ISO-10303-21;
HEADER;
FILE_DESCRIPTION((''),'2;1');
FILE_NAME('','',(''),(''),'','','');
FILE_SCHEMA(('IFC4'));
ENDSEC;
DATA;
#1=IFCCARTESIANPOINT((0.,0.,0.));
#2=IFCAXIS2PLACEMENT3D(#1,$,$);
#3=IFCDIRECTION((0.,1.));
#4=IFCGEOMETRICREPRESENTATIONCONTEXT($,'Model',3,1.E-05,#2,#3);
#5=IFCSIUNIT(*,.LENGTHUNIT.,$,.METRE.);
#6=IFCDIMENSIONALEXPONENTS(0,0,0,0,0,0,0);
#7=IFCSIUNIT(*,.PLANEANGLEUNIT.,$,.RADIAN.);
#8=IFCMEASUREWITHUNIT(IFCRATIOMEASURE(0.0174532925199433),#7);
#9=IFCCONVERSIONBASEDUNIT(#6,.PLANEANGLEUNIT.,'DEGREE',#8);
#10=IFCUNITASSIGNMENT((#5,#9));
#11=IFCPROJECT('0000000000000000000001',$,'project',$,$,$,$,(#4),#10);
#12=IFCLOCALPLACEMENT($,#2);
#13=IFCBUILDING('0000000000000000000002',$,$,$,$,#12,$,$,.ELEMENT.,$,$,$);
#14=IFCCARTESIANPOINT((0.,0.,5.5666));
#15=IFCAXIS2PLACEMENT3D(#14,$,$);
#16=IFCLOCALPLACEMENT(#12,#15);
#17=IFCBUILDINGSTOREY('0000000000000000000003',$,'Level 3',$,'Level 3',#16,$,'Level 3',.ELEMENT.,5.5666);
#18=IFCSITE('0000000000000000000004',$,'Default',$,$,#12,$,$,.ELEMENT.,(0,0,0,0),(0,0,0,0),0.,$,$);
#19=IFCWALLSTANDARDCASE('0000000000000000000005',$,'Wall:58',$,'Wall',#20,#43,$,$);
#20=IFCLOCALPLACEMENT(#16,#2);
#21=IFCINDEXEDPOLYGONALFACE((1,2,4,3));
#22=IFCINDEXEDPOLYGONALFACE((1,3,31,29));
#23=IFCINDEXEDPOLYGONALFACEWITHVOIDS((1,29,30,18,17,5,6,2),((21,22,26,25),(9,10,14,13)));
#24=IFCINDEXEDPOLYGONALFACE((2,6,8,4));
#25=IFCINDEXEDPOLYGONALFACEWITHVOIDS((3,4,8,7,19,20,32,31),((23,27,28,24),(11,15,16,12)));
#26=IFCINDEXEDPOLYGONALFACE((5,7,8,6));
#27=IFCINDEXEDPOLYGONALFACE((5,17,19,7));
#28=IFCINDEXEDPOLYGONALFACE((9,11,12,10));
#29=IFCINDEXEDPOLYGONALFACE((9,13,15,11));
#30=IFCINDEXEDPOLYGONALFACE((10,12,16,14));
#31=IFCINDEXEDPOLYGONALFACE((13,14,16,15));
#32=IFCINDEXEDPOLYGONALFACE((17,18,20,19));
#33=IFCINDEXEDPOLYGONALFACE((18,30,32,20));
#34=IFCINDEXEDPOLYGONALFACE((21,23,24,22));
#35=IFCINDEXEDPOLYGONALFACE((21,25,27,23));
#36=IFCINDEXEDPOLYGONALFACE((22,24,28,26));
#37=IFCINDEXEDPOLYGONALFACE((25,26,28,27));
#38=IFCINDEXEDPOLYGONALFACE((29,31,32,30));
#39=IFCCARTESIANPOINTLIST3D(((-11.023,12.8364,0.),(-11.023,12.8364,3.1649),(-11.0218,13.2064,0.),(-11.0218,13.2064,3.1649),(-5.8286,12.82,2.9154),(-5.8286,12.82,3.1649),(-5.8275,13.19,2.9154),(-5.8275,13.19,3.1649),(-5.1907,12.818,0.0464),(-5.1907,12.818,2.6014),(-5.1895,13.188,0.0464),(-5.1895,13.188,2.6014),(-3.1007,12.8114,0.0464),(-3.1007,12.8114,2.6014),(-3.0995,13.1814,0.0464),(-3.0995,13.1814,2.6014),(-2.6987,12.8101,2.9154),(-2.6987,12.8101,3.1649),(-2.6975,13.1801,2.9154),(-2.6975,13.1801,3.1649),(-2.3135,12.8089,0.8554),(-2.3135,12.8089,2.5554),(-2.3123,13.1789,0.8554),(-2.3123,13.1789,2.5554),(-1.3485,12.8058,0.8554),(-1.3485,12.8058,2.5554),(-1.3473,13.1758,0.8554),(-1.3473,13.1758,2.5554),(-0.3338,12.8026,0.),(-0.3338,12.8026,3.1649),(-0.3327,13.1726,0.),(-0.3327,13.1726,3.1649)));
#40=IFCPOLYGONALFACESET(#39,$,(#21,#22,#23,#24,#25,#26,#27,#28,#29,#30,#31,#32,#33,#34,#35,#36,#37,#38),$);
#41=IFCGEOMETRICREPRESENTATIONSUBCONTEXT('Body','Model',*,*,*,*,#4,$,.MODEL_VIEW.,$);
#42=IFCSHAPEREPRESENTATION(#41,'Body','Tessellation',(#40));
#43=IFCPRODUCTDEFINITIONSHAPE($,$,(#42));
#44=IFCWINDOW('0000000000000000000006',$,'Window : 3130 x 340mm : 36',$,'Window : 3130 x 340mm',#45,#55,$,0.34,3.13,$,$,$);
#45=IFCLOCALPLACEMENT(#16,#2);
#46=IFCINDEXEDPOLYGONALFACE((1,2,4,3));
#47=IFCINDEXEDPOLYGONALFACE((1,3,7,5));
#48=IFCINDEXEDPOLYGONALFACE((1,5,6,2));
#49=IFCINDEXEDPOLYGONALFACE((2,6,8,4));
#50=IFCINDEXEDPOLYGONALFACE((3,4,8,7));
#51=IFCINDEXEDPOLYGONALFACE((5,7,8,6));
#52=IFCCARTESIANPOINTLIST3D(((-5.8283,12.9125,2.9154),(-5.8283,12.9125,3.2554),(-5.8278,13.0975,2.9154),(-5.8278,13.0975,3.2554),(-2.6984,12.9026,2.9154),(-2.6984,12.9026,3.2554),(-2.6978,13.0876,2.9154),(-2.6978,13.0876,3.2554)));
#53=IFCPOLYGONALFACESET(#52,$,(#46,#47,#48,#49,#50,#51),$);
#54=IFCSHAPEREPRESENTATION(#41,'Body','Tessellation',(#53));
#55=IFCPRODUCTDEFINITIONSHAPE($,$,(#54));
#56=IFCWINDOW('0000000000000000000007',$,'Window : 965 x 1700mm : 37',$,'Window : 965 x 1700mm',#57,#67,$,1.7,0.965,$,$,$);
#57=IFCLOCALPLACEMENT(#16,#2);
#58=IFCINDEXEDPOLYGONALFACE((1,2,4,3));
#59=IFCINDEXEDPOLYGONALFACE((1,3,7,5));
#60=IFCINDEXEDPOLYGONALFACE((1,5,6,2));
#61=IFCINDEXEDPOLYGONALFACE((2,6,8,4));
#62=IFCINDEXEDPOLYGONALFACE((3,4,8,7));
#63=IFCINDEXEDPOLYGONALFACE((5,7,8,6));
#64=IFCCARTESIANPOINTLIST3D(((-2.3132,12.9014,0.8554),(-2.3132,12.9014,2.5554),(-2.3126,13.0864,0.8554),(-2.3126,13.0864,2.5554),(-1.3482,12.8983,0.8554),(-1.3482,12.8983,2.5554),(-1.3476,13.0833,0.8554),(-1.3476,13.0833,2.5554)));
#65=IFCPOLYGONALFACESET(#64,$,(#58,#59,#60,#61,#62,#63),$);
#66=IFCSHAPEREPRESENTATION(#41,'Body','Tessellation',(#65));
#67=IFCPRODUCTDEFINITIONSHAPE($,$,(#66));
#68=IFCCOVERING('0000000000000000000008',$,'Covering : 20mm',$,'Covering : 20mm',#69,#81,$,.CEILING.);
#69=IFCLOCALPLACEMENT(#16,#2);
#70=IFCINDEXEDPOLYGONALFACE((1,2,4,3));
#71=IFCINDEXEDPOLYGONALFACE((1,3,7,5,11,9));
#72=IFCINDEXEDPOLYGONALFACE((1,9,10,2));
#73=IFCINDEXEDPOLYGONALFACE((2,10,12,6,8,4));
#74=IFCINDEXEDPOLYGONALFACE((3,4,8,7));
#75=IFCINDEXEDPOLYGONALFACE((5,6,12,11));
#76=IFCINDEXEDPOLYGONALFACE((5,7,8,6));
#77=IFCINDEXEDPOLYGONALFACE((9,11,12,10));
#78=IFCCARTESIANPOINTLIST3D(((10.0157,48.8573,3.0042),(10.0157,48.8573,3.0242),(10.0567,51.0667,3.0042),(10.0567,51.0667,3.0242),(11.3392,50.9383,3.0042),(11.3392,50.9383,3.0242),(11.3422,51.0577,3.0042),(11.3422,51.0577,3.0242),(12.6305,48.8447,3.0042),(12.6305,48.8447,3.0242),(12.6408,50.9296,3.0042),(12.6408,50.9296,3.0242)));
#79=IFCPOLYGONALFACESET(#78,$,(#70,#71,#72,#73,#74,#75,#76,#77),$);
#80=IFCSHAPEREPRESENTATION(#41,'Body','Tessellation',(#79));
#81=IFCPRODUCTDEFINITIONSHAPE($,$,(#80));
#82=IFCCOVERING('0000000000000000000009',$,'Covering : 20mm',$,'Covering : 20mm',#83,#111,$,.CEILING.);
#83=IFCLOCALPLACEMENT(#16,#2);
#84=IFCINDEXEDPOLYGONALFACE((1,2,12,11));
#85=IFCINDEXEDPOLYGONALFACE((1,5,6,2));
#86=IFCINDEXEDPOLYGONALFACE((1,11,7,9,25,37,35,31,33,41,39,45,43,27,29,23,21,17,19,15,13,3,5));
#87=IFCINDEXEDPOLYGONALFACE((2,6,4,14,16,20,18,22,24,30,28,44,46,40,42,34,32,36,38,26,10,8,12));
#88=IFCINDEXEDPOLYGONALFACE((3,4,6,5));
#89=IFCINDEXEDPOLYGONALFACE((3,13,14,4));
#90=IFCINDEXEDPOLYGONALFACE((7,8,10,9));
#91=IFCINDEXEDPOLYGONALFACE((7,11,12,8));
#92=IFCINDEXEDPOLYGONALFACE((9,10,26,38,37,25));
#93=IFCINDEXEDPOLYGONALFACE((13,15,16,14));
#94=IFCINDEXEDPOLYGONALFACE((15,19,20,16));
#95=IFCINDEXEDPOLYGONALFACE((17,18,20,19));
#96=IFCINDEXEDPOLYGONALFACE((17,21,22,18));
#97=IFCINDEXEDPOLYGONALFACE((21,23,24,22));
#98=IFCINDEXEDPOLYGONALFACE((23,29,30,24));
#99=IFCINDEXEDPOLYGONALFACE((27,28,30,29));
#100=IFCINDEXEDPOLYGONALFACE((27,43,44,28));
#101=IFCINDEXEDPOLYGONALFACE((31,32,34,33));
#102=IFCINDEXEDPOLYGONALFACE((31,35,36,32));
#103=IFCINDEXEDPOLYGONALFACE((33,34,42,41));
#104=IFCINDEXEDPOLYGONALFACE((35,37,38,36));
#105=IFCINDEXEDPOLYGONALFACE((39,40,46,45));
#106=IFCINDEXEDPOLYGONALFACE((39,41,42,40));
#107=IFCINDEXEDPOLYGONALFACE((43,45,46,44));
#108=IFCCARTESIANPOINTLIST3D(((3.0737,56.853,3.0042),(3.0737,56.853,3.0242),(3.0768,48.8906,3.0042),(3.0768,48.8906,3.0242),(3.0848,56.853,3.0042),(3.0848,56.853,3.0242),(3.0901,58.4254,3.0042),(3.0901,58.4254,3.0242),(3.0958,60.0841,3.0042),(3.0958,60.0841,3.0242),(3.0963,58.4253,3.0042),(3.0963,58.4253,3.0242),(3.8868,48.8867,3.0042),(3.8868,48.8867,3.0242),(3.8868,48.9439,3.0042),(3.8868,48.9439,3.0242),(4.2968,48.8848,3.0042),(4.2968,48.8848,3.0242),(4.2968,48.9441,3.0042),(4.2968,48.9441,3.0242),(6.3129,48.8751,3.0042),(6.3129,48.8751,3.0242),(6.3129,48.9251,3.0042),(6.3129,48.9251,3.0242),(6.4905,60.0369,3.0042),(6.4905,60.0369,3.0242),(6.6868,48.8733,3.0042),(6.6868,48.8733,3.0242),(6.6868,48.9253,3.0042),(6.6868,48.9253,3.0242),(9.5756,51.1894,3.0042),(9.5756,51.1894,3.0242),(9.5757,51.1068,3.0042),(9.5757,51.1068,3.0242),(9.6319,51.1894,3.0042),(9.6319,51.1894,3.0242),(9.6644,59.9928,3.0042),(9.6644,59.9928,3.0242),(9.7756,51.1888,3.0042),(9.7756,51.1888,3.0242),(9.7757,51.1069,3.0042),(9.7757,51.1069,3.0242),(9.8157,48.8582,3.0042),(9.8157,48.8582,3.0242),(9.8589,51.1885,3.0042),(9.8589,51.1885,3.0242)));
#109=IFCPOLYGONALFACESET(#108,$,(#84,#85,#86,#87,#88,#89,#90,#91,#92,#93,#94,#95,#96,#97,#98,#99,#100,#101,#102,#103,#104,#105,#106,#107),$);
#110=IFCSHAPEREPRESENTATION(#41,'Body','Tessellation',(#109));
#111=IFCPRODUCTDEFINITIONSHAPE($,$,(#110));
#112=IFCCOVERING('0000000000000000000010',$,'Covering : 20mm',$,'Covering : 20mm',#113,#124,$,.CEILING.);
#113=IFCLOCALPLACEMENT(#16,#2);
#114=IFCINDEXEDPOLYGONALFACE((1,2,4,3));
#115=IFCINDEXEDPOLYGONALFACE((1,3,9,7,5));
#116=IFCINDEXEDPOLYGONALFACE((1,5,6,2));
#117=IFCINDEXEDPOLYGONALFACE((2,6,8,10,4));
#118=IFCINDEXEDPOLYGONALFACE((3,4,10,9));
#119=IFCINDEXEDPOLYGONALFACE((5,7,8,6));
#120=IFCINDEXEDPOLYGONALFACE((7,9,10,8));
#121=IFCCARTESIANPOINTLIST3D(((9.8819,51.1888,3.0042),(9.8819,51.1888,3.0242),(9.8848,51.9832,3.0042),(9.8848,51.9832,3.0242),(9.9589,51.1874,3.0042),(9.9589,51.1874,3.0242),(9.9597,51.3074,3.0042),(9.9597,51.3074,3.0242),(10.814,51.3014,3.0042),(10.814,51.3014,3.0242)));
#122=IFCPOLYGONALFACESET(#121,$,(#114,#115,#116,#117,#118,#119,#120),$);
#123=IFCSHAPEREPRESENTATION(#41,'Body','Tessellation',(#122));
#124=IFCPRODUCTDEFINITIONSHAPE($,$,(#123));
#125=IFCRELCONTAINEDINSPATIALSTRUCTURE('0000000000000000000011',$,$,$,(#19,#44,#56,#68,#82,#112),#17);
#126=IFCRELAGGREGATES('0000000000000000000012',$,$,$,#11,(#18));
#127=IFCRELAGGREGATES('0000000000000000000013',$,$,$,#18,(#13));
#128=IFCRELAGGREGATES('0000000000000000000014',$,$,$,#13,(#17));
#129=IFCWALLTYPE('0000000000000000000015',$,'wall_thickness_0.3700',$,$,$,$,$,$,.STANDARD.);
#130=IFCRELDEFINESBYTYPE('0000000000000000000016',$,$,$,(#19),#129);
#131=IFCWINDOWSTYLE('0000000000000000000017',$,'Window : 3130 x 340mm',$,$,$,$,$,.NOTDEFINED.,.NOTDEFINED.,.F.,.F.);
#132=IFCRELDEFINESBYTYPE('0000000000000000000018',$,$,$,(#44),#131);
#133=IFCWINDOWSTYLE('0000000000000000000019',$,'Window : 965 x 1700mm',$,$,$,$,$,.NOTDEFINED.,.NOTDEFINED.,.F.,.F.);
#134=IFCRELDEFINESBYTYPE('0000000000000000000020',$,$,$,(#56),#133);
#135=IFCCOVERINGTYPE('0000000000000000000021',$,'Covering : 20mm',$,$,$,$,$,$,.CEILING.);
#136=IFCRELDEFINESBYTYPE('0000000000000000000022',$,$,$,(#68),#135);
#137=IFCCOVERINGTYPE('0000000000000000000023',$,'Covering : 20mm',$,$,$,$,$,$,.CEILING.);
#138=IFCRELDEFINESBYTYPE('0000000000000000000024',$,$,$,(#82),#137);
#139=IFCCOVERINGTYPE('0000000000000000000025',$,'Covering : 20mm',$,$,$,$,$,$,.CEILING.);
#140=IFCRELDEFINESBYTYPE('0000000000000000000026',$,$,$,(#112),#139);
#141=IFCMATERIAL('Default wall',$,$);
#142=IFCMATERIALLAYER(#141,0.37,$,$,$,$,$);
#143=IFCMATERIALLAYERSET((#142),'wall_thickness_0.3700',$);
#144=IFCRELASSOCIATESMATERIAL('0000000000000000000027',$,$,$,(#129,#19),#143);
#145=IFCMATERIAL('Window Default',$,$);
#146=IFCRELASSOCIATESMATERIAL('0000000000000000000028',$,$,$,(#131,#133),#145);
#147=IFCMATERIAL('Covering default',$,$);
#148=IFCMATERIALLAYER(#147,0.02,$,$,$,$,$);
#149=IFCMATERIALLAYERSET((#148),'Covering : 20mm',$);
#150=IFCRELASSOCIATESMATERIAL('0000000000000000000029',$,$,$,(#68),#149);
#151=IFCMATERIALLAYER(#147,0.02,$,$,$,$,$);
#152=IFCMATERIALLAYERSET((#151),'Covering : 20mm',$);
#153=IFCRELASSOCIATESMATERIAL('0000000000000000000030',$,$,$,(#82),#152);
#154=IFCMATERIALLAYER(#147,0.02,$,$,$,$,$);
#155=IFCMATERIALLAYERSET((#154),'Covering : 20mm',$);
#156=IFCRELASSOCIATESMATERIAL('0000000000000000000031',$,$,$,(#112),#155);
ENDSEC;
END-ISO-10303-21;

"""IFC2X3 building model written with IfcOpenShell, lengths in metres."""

from ifc_helpers import new_model, entity, si_unit, converted_unit, direction, frame, frame_2d, origin, origin_with_axes, origin_2d_with_axis, place, context, subcontext, project, spatial, polyline, rectangle, outline, extrude, source, transform, mapped, material, layer, layer_set, layer_usage, type_object, type_shapes, element, fill, save


model = new_model("IFC2X3")

# Units and contexts
model_context = context("Model", 3, precision=1e-05, world=origin(), true_north=direction((0.0, 1.0)))
body_context = subcontext(model_context, "Body", "Model", "MODEL_VIEW")
ifc_project = project(units=[si_unit("LENGTHUNIT", "METRE"), converted_unit("PLANEANGLEUNIT", "DEGREE", entity("IfcRatioMeasure", 0.0174532925199433), si_unit("PLANEANGLEUNIT", "RADIAN"), dimensions=[0, 0, 0, 0, 0, 0, 0])], contexts=[model_context])

# Site, building, storey
placement = place(None, origin())
site = spatial("IfcSite", under=ifc_project, at=placement, Name="Default", CompositionType="ELEMENT", RefLatitude=(0, 0, 0, 0), RefLongitude=(0, 0, 0, 0), RefElevation=0.0)
building = spatial("IfcBuilding", under=site, at=placement, CompositionType="ELEMENT")
storey_placement = place(placement, frame((0.0, 0.0, 5.5666)))
storey = spatial("IfcBuildingStorey", under=building, at=storey_placement, Name="Level 3", ObjectType="Level 3", LongName="Level 3", CompositionType="ELEMENT", Elevation=5.5666)

# Wall, openings, windows
ifc_material_1 = material(Name="Default wall")
ifc_layer_1 = layer(ifc_material_1, 0.37)
ifc_layer_set_1 = layer_set([ifc_layer_1], Name="wall_thickness_0.3700")
ifc_layer_usage_1 = layer_usage(ifc_layer_set_1, "AXIS2", "POSITIVE", -0.185)
wall_type = type_object("IfcWallType", Name="wall_thickness_0.3700", PredefinedType="STANDARD", material=ifc_layer_set_1)
wall_placement = place(storey_placement, frame((-11.0224, 13.0214, 0.0), z_axis=(0.0, 0.0, 1.0), x_axis=(0.999995, -0.003165, 0.0)))
wall = element("IfcWallStandardCase", 1, at=wall_placement, inside=storey, type_object=wall_type, material=ifc_layer_usage_1, Name="Wall:58", ObjectType="Wall", context=body_context, shape_type="SweptSolid", body=[
    extrude(outline(polyline([(10.6892, -0.185), (10.6892, 0.185), (0.0, 0.185), (0.0, -0.185), (10.6892, -0.185)])), origin(), (0.0, 0.0, 1.0), 3.1649),
])
opening_1_placement = place(wall_placement, frame((5.8323, -0.185, 0.0464)))
element("IfcOpeningElement", 2, at=opening_1_placement, cuts=wall, ObjectType="Opening", context=body_context, shape_type="SweptSolid", body=[
    extrude(rectangle(XDim=2.09, YDim=2.555, at=frame_2d((1.2775, 1.045), x_axis=(0.0, 1.0))), frame((0.0, 0.0, 0.0), z_axis=(0.0, 1.0, 0.0), x_axis=(0.0, 0.0, 1.0)), (0.0, 0.0, 1.0), 0.37),
])
opening_2_placement = place(wall_placement, frame((5.1943, -0.185, 2.9154)))
opening_2 = element("IfcOpeningElement", 3, at=opening_2_placement, cuts=wall, ObjectType="Opening", context=body_context, shape_type="SweptSolid", body=[
    extrude(rectangle(XDim=3.13, YDim=0.34, at=frame_2d((0.17, 1.565), x_axis=(0.0, 1.0))), frame((0.0, 0.0, 0.0), z_axis=(0.0, 1.0, 0.0), x_axis=(0.0, 0.0, 1.0)), (0.0, 0.0, 1.0), 0.37),
])
opening_3_placement = place(wall_placement, frame((8.7095, -0.185, 0.8554)))
opening_3 = element("IfcOpeningElement", 4, at=opening_3_placement, cuts=wall, ObjectType="Opening", context=body_context, shape_type="SweptSolid", body=[
    extrude(rectangle(XDim=0.965, YDim=1.7, at=frame_2d((0.85, 0.4825), x_axis=(0.0, 1.0))), frame((0.0, 0.0, 0.0), z_axis=(0.0, 1.0, 0.0), x_axis=(0.0, 0.0, 1.0)), (0.0, 0.0, 1.0), 0.37),
])
ifc_material_2 = material(Name="Window Default")
window_style_1 = type_object("IfcWindowStyle", Name="Window : 3130 x 340mm", ConstructionType="NOTDEFINED", OperationType="NOTDEFINED", ParameterTakesPrecedence=False, Sizeable=False, material=ifc_material_2)
shared_shape_1 = source(origin(), body_context, "Body", "SweptSolid", [
    extrude(rectangle(XDim=0.185, YDim=3.13, at=origin_2d_with_axis()), frame((1.565, 0.185, 0.0), z_axis=(0.0, 0.0, 1.0), x_axis=(0.0, 1.0, 0.0)), (0.0, 0.0, 1.0), 0.34),
])
type_shapes(window_style_1, [shared_shape_1])
window_1_placement = place(opening_2_placement, origin())
window_1 = element("IfcWindow", 5, at=window_1_placement, inside=storey, type_object=window_style_1, Name="Window : 3130 x 340mm : 36", ObjectType="Window : 3130 x 340mm", OverallHeight=0.34, OverallWidth=3.13, context=body_context, shape_type="MappedRepresentation", body=[
    mapped(shared_shape_1, transform((0.0, 0.0, 0.0), scale=1.0)),
])
fill(opening_2, window_1)
window_style_2 = type_object("IfcWindowStyle", Name="Window : 965 x 1700mm", ConstructionType="NOTDEFINED", OperationType="NOTDEFINED", ParameterTakesPrecedence=False, Sizeable=False, material=ifc_material_2)
shared_shape_2 = source(origin(), body_context, "Body", "SweptSolid", [
    extrude(rectangle(XDim=0.185, YDim=0.965, at=origin_2d_with_axis()), frame((0.4825, 0.185, 0.0), z_axis=(0.0, 0.0, 1.0), x_axis=(0.0, 1.0, 0.0)), (0.0, 0.0, 1.0), 1.7),
])
type_shapes(window_style_2, [shared_shape_2])
window_2_placement = place(opening_3_placement, origin())
window_2 = element("IfcWindow", 6, at=window_2_placement, inside=storey, type_object=window_style_2, Name="Window : 965 x 1700mm : 37", ObjectType="Window : 965 x 1700mm", OverallHeight=1.7, OverallWidth=0.965, context=body_context, shape_type="MappedRepresentation", body=[
    mapped(shared_shape_2, transform((0.0, 0.0, 0.0), scale=1.0)),
])
fill(opening_3, window_2)

# Coverings
ifc_material_3 = material(Name="Covering default")
ifc_layer_2 = layer(ifc_material_3, 0.02)
ifc_layer_set_2 = layer_set([ifc_layer_2], Name="Covering : 20mm")
ifc_layer_usage_2 = layer_usage(ifc_layer_set_2, "AXIS3", "POSITIVE", 0.0)
covering_type_1 = type_object("IfcCoveringType", Name="Covering : 20mm", PredefinedType="CEILING")
covering_1_placement = place(placement, frame((0.0, 0.0, 8.5708)))
element("IfcCovering", 7, at=covering_1_placement, inside=storey, type_object=covering_type_1, material=ifc_layer_usage_2, Name="Covering : 20mm", ObjectType="Covering : 20mm", PredefinedType="CEILING", context=body_context, shape_type="SweptSolid", body=[
    extrude(outline(polyline([(10.0567, 51.0667), (11.3422, 51.0577), (11.3392, 50.9383), (12.6408, 50.9296), (12.6305, 48.8447), (10.0157, 48.8573), (10.0567, 51.0667)])), origin_with_axes(), (0.0, 0.0, 1.0), 0.02),
])
ifc_layer_3 = layer(ifc_material_3, 0.02)
ifc_layer_set_3 = layer_set([ifc_layer_3], Name="Covering : 20mm")
ifc_layer_usage_3 = layer_usage(ifc_layer_set_3, "AXIS3", "POSITIVE", 0.0)
covering_type_2 = type_object("IfcCoveringType", Name="Covering : 20mm", PredefinedType="CEILING")
covering_2_placement = place(placement, frame((0.0, 0.0, 8.5708)))
element("IfcCovering", 8, at=covering_2_placement, inside=storey, type_object=covering_type_2, material=ifc_layer_usage_3, Name="Covering : 20mm", ObjectType="Covering : 20mm", PredefinedType="CEILING", context=body_context, shape_type="SweptSolid", body=[
    extrude(outline(polyline([(3.0848, 56.853), (3.0737, 56.853), (3.0963, 58.4253), (3.0901, 58.4254), (3.0958, 60.0841), (6.4905, 60.0369), (9.6644, 59.9928), (9.6319, 51.1894), (9.5756, 51.1894), (9.5757, 51.1068), (9.7757, 51.1069), (9.7756, 51.1888), (9.8589, 51.1885), (9.8157, 48.8582), (6.6868, 48.8733), (6.6868, 48.9253), (6.3129, 48.9251), (6.3129, 48.8751), (4.2968, 48.8848), (4.2968, 48.9441), (3.8868, 48.9439), (3.8868, 48.8867), (3.0768, 48.8906), (3.0848, 56.853)])), origin_with_axes(), (0.0, 0.0, 1.0), 0.02),
])
ifc_layer_4 = layer(ifc_material_3, 0.02)
ifc_layer_set_4 = layer_set([ifc_layer_4], Name="Covering : 20mm")
ifc_layer_usage_4 = layer_usage(ifc_layer_set_4, "AXIS3", "POSITIVE", 0.0)
covering_type_3 = type_object("IfcCoveringType", Name="Covering : 20mm", PredefinedType="CEILING")
covering_3_placement = place(placement, frame((0.0, 0.0, 8.5708)))
element("IfcCovering", 9, at=covering_3_placement, inside=storey, type_object=covering_type_3, material=ifc_layer_usage_4, Name="Covering : 20mm", ObjectType="Covering : 20mm", PredefinedType="CEILING", context=body_context, shape_type="SweptSolid", body=[
    extrude(outline(polyline([(9.8848, 51.9832), (10.814, 51.3014), (9.9597, 51.3074), (9.9589, 51.1874), (9.8819, 51.1888), (9.8848, 51.9832)])), origin_with_axes(), (0.0, 0.0, 1.0), 0.02),
])

save(model, "model.ifc")
